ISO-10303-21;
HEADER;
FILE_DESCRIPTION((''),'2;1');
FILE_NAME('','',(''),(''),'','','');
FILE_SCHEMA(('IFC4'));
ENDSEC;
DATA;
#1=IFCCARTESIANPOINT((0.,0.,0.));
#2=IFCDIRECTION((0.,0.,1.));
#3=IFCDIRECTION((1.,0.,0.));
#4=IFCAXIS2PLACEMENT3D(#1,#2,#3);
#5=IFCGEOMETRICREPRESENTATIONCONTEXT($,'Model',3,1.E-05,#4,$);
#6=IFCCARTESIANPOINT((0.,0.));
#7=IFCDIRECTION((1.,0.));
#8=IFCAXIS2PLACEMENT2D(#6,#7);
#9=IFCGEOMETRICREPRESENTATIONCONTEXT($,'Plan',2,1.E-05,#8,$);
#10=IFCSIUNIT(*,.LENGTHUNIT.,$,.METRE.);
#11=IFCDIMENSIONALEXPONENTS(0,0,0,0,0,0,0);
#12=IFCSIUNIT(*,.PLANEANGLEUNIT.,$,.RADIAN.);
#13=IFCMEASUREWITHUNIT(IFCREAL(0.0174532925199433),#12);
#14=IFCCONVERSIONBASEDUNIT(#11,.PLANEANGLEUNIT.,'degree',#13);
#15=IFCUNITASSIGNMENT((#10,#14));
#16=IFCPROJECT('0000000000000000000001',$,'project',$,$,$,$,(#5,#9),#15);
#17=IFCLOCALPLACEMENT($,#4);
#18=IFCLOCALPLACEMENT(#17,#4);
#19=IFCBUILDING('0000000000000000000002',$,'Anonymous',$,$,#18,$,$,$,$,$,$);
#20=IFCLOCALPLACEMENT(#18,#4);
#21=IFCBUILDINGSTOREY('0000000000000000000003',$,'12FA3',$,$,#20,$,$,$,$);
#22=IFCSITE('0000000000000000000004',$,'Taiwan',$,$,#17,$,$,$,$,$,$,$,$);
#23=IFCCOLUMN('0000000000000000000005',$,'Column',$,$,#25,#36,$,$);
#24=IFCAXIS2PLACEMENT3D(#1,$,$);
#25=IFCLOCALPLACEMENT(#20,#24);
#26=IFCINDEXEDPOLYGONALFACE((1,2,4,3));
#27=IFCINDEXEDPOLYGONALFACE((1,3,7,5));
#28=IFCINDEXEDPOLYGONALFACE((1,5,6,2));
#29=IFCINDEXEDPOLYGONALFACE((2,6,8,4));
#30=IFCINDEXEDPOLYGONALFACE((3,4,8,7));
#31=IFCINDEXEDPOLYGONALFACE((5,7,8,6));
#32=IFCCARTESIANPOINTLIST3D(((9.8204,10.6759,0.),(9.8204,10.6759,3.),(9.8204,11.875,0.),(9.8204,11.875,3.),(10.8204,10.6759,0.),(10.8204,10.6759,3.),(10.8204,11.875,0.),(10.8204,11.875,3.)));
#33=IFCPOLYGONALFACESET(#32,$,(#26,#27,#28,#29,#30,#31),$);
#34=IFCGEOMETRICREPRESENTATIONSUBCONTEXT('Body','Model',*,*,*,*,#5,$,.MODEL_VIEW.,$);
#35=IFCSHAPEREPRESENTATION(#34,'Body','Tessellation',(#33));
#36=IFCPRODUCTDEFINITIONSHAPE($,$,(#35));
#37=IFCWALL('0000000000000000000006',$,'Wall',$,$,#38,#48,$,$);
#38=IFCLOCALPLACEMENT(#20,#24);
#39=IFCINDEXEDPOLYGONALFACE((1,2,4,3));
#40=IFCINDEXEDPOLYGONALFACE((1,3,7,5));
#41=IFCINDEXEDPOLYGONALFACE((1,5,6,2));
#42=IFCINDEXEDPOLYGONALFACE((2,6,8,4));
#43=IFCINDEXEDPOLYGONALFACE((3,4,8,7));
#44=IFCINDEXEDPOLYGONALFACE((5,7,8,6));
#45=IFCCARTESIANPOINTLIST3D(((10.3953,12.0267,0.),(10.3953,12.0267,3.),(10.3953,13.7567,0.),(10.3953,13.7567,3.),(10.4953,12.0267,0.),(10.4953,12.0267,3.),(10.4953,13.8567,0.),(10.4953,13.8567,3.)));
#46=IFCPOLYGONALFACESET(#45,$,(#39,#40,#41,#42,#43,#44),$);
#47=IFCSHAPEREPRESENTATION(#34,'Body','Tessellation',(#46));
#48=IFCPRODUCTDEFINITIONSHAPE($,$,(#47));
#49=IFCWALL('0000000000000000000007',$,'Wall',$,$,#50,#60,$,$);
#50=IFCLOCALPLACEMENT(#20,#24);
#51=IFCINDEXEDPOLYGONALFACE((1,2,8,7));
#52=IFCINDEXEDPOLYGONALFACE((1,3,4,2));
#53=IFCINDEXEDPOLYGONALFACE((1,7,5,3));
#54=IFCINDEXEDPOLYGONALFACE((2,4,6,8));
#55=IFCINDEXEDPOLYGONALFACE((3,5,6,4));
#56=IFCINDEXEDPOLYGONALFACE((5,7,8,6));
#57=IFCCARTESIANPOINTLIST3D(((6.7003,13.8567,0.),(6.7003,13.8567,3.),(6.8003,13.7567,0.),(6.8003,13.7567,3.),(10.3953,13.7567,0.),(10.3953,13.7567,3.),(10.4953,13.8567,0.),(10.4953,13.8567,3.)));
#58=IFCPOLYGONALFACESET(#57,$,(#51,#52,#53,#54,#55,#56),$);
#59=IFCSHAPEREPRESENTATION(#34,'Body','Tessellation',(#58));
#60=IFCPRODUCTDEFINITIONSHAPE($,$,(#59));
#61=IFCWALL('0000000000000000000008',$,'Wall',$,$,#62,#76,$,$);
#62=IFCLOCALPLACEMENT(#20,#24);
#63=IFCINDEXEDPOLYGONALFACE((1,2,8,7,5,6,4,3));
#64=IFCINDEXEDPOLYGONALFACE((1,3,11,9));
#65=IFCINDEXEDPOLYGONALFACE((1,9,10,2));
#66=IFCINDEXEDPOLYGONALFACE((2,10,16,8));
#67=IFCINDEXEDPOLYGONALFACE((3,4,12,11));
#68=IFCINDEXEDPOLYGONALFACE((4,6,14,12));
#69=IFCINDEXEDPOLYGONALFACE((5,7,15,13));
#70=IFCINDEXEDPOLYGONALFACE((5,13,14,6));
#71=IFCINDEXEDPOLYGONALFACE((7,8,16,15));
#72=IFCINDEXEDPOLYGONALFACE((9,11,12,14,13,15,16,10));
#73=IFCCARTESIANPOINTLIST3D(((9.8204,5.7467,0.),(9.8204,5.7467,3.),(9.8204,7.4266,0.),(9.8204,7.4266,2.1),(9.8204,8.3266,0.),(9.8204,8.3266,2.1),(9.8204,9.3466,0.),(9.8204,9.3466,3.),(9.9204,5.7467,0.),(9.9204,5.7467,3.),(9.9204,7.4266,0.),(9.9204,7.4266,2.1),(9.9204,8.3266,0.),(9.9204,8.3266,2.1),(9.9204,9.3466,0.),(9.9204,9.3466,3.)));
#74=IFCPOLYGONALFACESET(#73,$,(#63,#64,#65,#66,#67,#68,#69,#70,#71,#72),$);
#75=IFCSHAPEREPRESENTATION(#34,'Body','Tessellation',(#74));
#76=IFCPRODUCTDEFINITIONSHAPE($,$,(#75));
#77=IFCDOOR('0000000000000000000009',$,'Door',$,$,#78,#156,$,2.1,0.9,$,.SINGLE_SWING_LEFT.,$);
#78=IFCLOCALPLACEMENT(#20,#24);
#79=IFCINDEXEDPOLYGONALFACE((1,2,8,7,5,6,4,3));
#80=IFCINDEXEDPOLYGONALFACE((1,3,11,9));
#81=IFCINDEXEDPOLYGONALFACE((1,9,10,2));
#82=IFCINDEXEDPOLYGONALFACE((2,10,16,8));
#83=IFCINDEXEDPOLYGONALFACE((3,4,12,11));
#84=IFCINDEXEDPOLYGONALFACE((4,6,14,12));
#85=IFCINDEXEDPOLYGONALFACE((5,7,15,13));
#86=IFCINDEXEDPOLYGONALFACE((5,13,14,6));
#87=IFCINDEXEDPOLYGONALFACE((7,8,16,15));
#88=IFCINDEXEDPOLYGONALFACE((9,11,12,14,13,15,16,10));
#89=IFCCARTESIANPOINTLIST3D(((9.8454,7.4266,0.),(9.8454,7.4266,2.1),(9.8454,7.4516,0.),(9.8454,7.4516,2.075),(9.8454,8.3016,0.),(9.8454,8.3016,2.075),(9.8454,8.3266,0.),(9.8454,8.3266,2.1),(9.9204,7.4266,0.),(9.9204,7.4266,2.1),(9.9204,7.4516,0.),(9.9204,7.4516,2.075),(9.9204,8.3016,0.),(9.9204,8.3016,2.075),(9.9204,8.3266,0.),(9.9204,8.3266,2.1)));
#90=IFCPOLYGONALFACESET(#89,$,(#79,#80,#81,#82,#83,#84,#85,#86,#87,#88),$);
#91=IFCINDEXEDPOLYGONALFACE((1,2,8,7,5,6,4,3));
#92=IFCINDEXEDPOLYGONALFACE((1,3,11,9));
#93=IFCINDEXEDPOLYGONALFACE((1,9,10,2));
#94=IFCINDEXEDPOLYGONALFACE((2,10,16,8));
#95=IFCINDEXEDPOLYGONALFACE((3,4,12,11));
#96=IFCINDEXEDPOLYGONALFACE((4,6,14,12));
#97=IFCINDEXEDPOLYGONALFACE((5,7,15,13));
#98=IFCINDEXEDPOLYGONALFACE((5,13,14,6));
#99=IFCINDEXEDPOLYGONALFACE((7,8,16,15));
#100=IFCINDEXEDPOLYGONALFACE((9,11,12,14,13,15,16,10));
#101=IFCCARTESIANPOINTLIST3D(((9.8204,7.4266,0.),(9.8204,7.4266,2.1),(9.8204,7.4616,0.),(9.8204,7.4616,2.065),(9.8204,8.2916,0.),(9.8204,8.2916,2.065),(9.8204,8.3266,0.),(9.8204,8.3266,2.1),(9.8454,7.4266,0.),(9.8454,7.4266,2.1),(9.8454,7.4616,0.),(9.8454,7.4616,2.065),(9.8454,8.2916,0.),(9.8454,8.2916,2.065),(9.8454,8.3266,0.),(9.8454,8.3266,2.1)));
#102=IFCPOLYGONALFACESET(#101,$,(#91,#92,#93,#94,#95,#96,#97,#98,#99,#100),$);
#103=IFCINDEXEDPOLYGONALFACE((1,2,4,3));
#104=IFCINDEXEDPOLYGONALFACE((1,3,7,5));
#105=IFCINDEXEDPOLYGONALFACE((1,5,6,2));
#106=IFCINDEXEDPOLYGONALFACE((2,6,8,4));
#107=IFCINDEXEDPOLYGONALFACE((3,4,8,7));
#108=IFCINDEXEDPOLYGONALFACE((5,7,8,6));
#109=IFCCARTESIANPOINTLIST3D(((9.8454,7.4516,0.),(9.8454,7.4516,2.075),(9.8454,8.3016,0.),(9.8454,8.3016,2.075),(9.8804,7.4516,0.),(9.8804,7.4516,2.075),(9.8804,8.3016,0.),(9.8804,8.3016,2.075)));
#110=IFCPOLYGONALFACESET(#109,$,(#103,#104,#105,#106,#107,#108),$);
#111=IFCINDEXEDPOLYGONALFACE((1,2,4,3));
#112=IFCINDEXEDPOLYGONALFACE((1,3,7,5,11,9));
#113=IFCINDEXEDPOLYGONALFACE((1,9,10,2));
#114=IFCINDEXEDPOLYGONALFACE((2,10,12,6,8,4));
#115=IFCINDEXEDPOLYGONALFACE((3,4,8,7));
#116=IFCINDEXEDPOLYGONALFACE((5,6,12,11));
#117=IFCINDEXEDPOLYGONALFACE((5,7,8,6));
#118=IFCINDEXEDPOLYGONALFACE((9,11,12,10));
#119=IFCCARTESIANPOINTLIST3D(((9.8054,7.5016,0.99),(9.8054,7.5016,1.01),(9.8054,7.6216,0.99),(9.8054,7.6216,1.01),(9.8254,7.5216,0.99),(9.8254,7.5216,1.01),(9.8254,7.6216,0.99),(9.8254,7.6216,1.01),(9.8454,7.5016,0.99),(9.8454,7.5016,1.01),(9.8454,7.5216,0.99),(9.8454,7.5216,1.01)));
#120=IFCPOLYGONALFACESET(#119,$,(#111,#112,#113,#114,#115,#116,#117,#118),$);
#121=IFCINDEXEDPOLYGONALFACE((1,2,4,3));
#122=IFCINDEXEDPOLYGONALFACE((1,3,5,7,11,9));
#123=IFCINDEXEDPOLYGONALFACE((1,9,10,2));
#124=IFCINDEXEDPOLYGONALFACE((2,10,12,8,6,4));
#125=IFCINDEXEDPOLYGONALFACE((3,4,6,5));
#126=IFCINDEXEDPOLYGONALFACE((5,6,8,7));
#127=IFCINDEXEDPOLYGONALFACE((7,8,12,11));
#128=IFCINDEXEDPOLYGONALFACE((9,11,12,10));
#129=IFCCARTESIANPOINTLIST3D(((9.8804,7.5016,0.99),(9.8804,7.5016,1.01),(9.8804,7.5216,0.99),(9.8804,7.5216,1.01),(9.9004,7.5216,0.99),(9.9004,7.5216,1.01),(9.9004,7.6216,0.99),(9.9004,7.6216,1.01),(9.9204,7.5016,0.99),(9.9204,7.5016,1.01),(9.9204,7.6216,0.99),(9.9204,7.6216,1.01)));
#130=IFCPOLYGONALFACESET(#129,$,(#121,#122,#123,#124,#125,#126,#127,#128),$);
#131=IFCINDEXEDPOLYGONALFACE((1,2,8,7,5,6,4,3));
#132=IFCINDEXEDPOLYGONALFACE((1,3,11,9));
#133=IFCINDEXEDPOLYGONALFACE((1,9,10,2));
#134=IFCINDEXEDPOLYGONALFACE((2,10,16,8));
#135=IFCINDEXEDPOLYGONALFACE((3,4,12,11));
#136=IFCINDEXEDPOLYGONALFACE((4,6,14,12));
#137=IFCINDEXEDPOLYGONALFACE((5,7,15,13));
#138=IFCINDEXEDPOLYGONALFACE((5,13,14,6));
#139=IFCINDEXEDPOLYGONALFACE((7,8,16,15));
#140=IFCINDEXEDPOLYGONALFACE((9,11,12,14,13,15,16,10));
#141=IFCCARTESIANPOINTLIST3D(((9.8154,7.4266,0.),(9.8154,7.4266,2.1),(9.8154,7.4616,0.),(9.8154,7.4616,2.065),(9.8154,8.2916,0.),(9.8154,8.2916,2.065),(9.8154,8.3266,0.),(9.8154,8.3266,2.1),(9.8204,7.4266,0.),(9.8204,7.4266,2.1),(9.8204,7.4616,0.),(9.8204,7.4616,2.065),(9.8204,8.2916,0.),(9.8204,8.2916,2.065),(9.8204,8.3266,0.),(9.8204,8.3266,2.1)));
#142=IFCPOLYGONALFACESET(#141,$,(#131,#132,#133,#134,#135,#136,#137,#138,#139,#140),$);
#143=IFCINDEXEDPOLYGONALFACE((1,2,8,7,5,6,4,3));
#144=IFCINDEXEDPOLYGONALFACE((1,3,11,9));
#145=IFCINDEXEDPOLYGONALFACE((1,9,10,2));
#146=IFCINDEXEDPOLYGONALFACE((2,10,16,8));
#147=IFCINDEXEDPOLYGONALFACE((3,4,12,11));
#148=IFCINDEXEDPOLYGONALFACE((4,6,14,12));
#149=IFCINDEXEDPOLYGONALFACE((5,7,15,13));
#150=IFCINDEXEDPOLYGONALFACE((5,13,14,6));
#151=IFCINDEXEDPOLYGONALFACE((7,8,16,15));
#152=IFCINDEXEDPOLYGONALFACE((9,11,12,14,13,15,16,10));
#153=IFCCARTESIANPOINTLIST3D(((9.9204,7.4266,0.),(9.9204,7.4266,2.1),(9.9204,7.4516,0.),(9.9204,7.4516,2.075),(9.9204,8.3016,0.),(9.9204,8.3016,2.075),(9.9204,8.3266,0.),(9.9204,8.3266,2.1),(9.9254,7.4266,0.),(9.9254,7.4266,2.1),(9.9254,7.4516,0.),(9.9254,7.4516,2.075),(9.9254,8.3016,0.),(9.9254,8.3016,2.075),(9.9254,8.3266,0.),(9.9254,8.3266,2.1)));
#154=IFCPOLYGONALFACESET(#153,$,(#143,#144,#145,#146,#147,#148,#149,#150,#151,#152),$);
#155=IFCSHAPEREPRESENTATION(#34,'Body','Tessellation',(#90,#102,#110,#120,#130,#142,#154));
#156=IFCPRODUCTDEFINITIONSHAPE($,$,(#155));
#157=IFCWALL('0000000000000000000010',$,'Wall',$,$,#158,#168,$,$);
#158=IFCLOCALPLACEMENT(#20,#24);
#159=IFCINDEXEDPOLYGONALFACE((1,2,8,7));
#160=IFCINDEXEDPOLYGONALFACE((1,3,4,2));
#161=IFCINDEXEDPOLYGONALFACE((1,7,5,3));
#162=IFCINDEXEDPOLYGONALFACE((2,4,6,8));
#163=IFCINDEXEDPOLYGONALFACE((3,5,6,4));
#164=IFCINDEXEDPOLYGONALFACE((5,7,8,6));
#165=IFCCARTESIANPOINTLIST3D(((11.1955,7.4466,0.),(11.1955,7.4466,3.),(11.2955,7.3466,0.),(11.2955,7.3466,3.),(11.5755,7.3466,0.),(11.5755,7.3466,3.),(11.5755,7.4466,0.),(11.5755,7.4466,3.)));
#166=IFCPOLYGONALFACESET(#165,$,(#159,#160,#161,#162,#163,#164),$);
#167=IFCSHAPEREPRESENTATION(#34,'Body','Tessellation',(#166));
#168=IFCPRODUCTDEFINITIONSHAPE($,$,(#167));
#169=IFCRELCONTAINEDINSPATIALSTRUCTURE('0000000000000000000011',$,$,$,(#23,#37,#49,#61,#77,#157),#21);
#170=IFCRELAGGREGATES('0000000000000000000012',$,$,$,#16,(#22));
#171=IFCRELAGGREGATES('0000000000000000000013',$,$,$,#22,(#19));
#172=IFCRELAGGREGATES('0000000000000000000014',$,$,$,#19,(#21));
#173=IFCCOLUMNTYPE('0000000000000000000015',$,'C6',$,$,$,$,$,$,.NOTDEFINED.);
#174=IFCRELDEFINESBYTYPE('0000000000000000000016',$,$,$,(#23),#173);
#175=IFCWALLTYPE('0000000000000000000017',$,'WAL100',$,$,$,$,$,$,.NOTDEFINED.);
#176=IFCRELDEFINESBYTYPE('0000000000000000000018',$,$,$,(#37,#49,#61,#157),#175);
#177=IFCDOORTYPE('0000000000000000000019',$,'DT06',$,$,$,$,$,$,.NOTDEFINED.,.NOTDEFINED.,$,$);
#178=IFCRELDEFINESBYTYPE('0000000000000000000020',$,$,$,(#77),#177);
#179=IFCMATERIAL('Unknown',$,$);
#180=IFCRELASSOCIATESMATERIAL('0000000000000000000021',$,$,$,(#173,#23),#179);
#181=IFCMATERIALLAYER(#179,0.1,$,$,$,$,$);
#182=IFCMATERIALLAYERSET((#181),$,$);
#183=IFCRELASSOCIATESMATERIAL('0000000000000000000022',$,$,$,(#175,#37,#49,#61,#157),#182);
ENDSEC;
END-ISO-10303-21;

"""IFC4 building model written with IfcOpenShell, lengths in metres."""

from ifc_helpers import new_model, entity, si_unit, converted_unit, frame, origin_with_axes, origin_2d_with_axis, place, context, subcontext, project, spatial, line, indexed_curve, outline, extrude, shape, source, transform, mapped, material, layer, layer_set, layer_usage, material_profile, profile_set, profile_usage, type_object, type_shapes, element, fill, save


model = new_model("IFC4")

# Units and contexts
model_context = context("Model", 3, precision=1e-05, world=origin_with_axes())
plan_context = context("Plan", 2, precision=1e-05, world=origin_2d_with_axis())
body_context_1 = subcontext(model_context, "Body", "Model", "MODEL_VIEW")
body_context_2 = subcontext(plan_context, "Body", "Plan", "PLAN_VIEW")
ifc_project = project(units=[si_unit("LENGTHUNIT", "METRE"), converted_unit("PLANEANGLEUNIT", "degree", entity("IfcReal", 0.0174532925199433), si_unit("PLANEANGLEUNIT", "RADIAN"), dimensions=[0, 0, 0, 0, 0, 0, 0])], contexts=[model_context, plan_context])

# Site, building, storey
site_placement = place(None, origin_with_axes())
site = spatial("IfcSite", under=ifc_project, at=site_placement, Name="Taiwan")
building_placement = place(site_placement, origin_with_axes())
building = spatial("IfcBuilding", under=site, at=building_placement, Name="Anonymous")
storey_placement = place(building_placement, origin_with_axes())
storey = spatial("IfcBuildingStorey", under=building, at=storey_placement, Name="12FA3")

# Column
ifc_material = material(Name="Unknown")
ifc_material_profile = material_profile(ifc_material, outline(indexed_curve([(0.0, 1.1992), (1.0, 1.1992), (1.0, 0.0), (0.0, 0.0), (0.0, 1.1992)])))
ifc_profile_set = profile_set([ifc_material_profile])
ifc_profile_usage = profile_usage(ifc_profile_set, cardinal=5)
column_type = type_object("IfcColumnType", Name="C6", PredefinedType="NOTDEFINED", material=ifc_profile_set)
column_placement = place(storey_placement, frame((9.8204, 10.6759, 0.0), z_axis=(0.0, 0.0, 1.0), x_axis=(1.0, 0.0, 0.0)))
element("IfcColumn", 1, at=column_placement, inside=storey, type_object=column_type, material=ifc_profile_usage, Name="Column", context=body_context_1, shape_type="SweptSolid", body=[
    extrude(outline(indexed_curve([(0.0, 1.1992), (1.0, 1.1992), (1.0, 0.0), (0.0, 0.0), (0.0, 1.1992)])), origin_with_axes(), (0.0, 0.0, 1.0), 3.0),
])

# Walls
ifc_layer_1 = layer(ifc_material, 0.1)
ifc_layer_set_1 = layer_set([ifc_layer_1])
ifc_layer_usage_1 = layer_usage(ifc_layer_set_1, "AXIS2", "POSITIVE", 0.0)
wall_type_1 = type_object("IfcWallType", Name="WAL100", PredefinedType="NOTDEFINED", material=ifc_layer_set_1)
wall_1_placement = place(storey_placement, frame((10.4953, 12.0267, 0.0), z_axis=(0.0, 0.0, 1.0), x_axis=(0.0, 1.0, 0.0)))
element("IfcWall", 2, at=wall_1_placement, inside=storey, type_object=wall_type_1, material=ifc_layer_usage_1, Name="Wall", context=body_context_1, shape_type="SweptSolid", body=[
    extrude(outline(indexed_curve([(0.0, 0.0), (0.0, 0.1), (1.73, 0.1), (1.83, 0.0)], segments=[line(1, 2, 3, 4, 1)])), origin_with_axes(), (0.0, 0.0, 1.0), 3.0),
])
ifc_layer_usage_2 = layer_usage(ifc_layer_set_1, "AXIS2", "POSITIVE", 0.0)
wall_2_placement = place(storey_placement, frame((10.4953, 13.8567, 0.0), z_axis=(0.0, 0.0, 1.0), x_axis=(-1.0, 0.0, 0.0)))
element("IfcWall", 3, at=wall_2_placement, inside=storey, type_object=wall_type_1, material=ifc_layer_usage_2, Name="Wall", context=body_context_1, shape_type="SweptSolid", body=[
    extrude(outline(indexed_curve([(0.0, 0.0), (0.1, 0.1), (3.695, 0.1), (3.795, 0.0)], segments=[line(1, 2, 3, 4, 1)])), origin_with_axes(), (0.0, 0.0, 1.0), 3.0),
])

# Wall, opening, door
ifc_layer_usage_3 = layer_usage(ifc_layer_set_1, "AXIS2", "POSITIVE", 0.0)
wall_3_placement = place(storey_placement, frame((9.8204, 9.3466, 0.0), z_axis=(0.0, 0.0, 1.0), x_axis=(0.0, -1.0, 0.0)))
wall_3 = element("IfcWall", 4, at=wall_3_placement, inside=storey, type_object=wall_type_1, material=ifc_layer_usage_3, Name="Wall", context=body_context_1, shape_type="SweptSolid", body=[
    extrude(outline(indexed_curve([(0.0, 0.0), (0.0, 0.1), (3.5999, 0.1), (3.5999, 0.0)], segments=[line(1, 2, 3, 4, 1)])), origin_with_axes(), (0.0, 0.0, 1.0), 3.0),
])
shared_shape_1 = source(origin_with_axes(), body_context_1, "Body", "SweptSolid", [
    extrude(outline(indexed_curve([(0.0, 0.0), (0.9, 0.0), (0.9, 2.1), (0.0, 2.1)], segments=[line(1, 2, 3, 4, 1)])), frame((0.0, -0.6, 0.0), z_axis=(0.0, -1.0, 0.0), x_axis=(1.0, 0.0, 0.0)), (0.0, 0.0, -1.0), 1.2),
])
opening_1_placement = place(wall_3_placement, frame((1.0199, 0.0, 0.0), z_axis=(0.0, 0.0, 1.0), x_axis=(1.0, 0.0, 0.0)))
opening_1 = element("IfcOpeningElement", 5, at=opening_1_placement, cuts=wall_3, PredefinedType="OPENING", context=body_context_1, shape_type="MappedRepresentation", body=[
    mapped(shared_shape_1, transform((0.0, 0.0, 0.0), x_axis=(1.0, 0.0, 0.0), y_axis=(0.0, 1.0, 0.0), z_axis=(0.0, 0.0, 1.0), scale=1.0)),
])
door_type_1 = type_object("IfcDoorType", Name="DT06", OperationType="NOTDEFINED", PredefinedType="NOTDEFINED")
shared_shape_2 = source(origin_with_axes(), body_context_1, "Body", "SweptSolid", [
    extrude(outline(indexed_curve([(0.0, 0.0), (0.0, 2.1), (0.9, 2.1), (0.9, 0.0), (0.875, 0.0), (0.875, 2.075), (0.025, 2.075), (0.025, 0.0)], segments=[line(1, 2, 3, 4, 5, 6, 7, 8, 1)])), frame((0.0, 0.025, 0.0), z_axis=(0.0, -1.0, 0.0), x_axis=(1.0, 0.0, 0.0)), (0.0, 0.0, -1.0), 0.075),
    extrude(outline(indexed_curve([(0.0, 0.0), (0.0, 2.1), (0.9, 2.1), (0.9, 0.0), (0.865, 0.0), (0.865, 2.065), (0.035, 2.065), (0.035, 0.0)], segments=[line(1, 2, 3, 4, 5, 6, 7, 8, 1)])), frame((0.0, 0.0, 0.0), z_axis=(0.0, -1.0, 0.0), x_axis=(1.0, 0.0, 0.0)), (0.0, 0.0, -1.0), 0.025),
    extrude(outline(indexed_curve([(0.0, 0.0), (0.85, 0.0), (0.85, 0.035), (0.0, 0.035)], segments=[line(1, 2, 3, 4, 1)])), frame((0.025, 0.025, 0.0), z_axis=(0.0, 0.0, 1.0), x_axis=(1.0, 0.0, 0.0)), (0.0, 0.0, 1.0), 2.075),
    extrude(outline(indexed_curve([(0.0, 0.0), (0.0, -0.04), (-0.12, -0.04), (-0.12, -0.02), (-0.02, -0.02), (-0.02, 0.0)], segments=[line(1, 2, 3, 4, 5, 6, 1)])), frame((0.825, 0.025, 0.99), z_axis=(0.0, 0.0, 1.0), x_axis=(1.0, 0.0, 0.0)), (0.0, 0.0, 1.0), 0.02),
    extrude(outline(indexed_curve([(0.0, 0.0), (0.0, 0.04), (-0.12, 0.04), (-0.12, 0.02), (-0.02, 0.02), (-0.02, 0.0)], segments=[line(1, 2, 3, 4, 5, 6, 1)])), frame((0.825, 0.06, 0.99), z_axis=(0.0, 0.0, 1.0), x_axis=(1.0, 0.0, 0.0)), (0.0, 0.0, 1.0), 0.02),
    extrude(outline(indexed_curve([(0.0, 0.0), (0.0, 2.1), (0.9, 2.1), (0.9, 0.0), (0.865, 0.0), (0.865, 2.065), (0.035, 2.065), (0.035, 0.0)], segments=[line(1, 2, 3, 4, 5, 6, 7, 8, 1)])), frame((0.0, -0.005, 0.0), z_axis=(0.0, -1.0, 0.0), x_axis=(1.0, 0.0, 0.0)), (0.0, 0.0, -1.0), 0.005),
    extrude(outline(indexed_curve([(0.0, 0.0), (0.0, 2.1), (0.9, 2.1), (0.9, 0.0), (0.875, 0.0), (0.875, 2.075), (0.025, 2.075), (0.025, 0.0)], segments=[line(1, 2, 3, 4, 5, 6, 7, 8, 1)])), frame((0.0, 0.1, 0.0), z_axis=(0.0, -1.0, 0.0), x_axis=(1.0, 0.0, 0.0)), (0.0, 0.0, -1.0), 0.005),
])
shared_shape_3 = source(origin_with_axes(), body_context_2, "Body", "Curve2D", [
    entity("IfcIndexedPolyCurve", entity("IfcCartesianPointList2D", [[0.0, 0.0], [0.0, 0.1], [0.025, 0.1], [0.025, 0.025], [0.035, 0.025], [0.035, 0.0]]), [entity("IfcLineIndex", [1, 2, 3, 4, 5, 6, 1])]),
    entity("IfcIndexedPolyCurve", entity("IfcCartesianPointList2D", [[0.9, 0.0], [0.9, 0.1], [0.875, 0.1], [0.875, 0.025], [0.865, 0.025], [0.865, 0.0]]), [entity("IfcLineIndex", [1, 2, 3, 4, 5, 6, 1])]),
    entity("IfcTrimmedCurve", entity("IfcEllipse", entity("IfcAxis2Placement2D", entity("IfcCartesianPoint", [0.06, 0.1]), entity("IfcDirection", [1.0, 0.0])), 0.815, 0.85), [entity("IfcCartesianPoint", [0.875, 0.1])], [entity("IfcCartesianPoint", [0.06, 0.95])], True, "CARTESIAN"),
    entity("IfcIndexedPolyCurve", entity("IfcCartesianPointList2D", [[0.025, 0.1], [0.06, 0.1], [0.06, 0.95], [0.025, 0.95]]), [entity("IfcLineIndex", [1, 2, 3, 4, 1])]),
])
type_shapes(door_type_1, [shared_shape_2, shared_shape_3])
door_1_placement = place(opening_1_placement, origin_with_axes())
door_1 = element("IfcDoor", 6, at=door_1_placement, inside=storey, type_object=door_type_1, Name="Door", OperationType="SINGLE_SWING_LEFT", OverallHeight=2.1, OverallWidth=0.9, shapes=[
    shape(body_context_1, "Body", "MappedRepresentation", [mapped(shared_shape_2, transform((0.0, 0.0, 0.0), x_axis=(1.0, 0.0, 0.0), y_axis=(0.0, 1.0, 0.0), z_axis=(0.0, 0.0, 1.0), scale=1.0))]),
    shape(body_context_2, "Body", "MappedRepresentation", [mapped(shared_shape_3, transform((0.0, 0.0, 0.0), x_axis=(1.0, 0.0, 0.0), y_axis=(0.0, 1.0, 0.0), z_axis=(0.0, 0.0, 1.0), scale=1.0))]),
])
fill(opening_1, door_1)

# Wall
ifc_layer_usage_4 = layer_usage(ifc_layer_set_1, "AXIS2", "POSITIVE", 0.0)
wall_4_placement = place(storey_placement, frame((11.5755, 7.4466, 0.0), z_axis=(0.0, 0.0, 1.0), x_axis=(-1.0, 0.0, 0.0)))
element("IfcWall", 7, at=wall_4_placement, inside=storey, type_object=wall_type_1, material=ifc_layer_usage_4, Name="Wall", context=body_context_1, shape_type="SweptSolid", body=[
    extrude(outline(indexed_curve([(0.0, 0.0), (0.0, 0.1), (0.28, 0.1), (0.38, 0.0)], segments=[line(1, 2, 3, 4, 1)])), origin_with_axes(), (0.0, 0.0, 1.0), 3.0),
])

save(model, "model.ifc")
